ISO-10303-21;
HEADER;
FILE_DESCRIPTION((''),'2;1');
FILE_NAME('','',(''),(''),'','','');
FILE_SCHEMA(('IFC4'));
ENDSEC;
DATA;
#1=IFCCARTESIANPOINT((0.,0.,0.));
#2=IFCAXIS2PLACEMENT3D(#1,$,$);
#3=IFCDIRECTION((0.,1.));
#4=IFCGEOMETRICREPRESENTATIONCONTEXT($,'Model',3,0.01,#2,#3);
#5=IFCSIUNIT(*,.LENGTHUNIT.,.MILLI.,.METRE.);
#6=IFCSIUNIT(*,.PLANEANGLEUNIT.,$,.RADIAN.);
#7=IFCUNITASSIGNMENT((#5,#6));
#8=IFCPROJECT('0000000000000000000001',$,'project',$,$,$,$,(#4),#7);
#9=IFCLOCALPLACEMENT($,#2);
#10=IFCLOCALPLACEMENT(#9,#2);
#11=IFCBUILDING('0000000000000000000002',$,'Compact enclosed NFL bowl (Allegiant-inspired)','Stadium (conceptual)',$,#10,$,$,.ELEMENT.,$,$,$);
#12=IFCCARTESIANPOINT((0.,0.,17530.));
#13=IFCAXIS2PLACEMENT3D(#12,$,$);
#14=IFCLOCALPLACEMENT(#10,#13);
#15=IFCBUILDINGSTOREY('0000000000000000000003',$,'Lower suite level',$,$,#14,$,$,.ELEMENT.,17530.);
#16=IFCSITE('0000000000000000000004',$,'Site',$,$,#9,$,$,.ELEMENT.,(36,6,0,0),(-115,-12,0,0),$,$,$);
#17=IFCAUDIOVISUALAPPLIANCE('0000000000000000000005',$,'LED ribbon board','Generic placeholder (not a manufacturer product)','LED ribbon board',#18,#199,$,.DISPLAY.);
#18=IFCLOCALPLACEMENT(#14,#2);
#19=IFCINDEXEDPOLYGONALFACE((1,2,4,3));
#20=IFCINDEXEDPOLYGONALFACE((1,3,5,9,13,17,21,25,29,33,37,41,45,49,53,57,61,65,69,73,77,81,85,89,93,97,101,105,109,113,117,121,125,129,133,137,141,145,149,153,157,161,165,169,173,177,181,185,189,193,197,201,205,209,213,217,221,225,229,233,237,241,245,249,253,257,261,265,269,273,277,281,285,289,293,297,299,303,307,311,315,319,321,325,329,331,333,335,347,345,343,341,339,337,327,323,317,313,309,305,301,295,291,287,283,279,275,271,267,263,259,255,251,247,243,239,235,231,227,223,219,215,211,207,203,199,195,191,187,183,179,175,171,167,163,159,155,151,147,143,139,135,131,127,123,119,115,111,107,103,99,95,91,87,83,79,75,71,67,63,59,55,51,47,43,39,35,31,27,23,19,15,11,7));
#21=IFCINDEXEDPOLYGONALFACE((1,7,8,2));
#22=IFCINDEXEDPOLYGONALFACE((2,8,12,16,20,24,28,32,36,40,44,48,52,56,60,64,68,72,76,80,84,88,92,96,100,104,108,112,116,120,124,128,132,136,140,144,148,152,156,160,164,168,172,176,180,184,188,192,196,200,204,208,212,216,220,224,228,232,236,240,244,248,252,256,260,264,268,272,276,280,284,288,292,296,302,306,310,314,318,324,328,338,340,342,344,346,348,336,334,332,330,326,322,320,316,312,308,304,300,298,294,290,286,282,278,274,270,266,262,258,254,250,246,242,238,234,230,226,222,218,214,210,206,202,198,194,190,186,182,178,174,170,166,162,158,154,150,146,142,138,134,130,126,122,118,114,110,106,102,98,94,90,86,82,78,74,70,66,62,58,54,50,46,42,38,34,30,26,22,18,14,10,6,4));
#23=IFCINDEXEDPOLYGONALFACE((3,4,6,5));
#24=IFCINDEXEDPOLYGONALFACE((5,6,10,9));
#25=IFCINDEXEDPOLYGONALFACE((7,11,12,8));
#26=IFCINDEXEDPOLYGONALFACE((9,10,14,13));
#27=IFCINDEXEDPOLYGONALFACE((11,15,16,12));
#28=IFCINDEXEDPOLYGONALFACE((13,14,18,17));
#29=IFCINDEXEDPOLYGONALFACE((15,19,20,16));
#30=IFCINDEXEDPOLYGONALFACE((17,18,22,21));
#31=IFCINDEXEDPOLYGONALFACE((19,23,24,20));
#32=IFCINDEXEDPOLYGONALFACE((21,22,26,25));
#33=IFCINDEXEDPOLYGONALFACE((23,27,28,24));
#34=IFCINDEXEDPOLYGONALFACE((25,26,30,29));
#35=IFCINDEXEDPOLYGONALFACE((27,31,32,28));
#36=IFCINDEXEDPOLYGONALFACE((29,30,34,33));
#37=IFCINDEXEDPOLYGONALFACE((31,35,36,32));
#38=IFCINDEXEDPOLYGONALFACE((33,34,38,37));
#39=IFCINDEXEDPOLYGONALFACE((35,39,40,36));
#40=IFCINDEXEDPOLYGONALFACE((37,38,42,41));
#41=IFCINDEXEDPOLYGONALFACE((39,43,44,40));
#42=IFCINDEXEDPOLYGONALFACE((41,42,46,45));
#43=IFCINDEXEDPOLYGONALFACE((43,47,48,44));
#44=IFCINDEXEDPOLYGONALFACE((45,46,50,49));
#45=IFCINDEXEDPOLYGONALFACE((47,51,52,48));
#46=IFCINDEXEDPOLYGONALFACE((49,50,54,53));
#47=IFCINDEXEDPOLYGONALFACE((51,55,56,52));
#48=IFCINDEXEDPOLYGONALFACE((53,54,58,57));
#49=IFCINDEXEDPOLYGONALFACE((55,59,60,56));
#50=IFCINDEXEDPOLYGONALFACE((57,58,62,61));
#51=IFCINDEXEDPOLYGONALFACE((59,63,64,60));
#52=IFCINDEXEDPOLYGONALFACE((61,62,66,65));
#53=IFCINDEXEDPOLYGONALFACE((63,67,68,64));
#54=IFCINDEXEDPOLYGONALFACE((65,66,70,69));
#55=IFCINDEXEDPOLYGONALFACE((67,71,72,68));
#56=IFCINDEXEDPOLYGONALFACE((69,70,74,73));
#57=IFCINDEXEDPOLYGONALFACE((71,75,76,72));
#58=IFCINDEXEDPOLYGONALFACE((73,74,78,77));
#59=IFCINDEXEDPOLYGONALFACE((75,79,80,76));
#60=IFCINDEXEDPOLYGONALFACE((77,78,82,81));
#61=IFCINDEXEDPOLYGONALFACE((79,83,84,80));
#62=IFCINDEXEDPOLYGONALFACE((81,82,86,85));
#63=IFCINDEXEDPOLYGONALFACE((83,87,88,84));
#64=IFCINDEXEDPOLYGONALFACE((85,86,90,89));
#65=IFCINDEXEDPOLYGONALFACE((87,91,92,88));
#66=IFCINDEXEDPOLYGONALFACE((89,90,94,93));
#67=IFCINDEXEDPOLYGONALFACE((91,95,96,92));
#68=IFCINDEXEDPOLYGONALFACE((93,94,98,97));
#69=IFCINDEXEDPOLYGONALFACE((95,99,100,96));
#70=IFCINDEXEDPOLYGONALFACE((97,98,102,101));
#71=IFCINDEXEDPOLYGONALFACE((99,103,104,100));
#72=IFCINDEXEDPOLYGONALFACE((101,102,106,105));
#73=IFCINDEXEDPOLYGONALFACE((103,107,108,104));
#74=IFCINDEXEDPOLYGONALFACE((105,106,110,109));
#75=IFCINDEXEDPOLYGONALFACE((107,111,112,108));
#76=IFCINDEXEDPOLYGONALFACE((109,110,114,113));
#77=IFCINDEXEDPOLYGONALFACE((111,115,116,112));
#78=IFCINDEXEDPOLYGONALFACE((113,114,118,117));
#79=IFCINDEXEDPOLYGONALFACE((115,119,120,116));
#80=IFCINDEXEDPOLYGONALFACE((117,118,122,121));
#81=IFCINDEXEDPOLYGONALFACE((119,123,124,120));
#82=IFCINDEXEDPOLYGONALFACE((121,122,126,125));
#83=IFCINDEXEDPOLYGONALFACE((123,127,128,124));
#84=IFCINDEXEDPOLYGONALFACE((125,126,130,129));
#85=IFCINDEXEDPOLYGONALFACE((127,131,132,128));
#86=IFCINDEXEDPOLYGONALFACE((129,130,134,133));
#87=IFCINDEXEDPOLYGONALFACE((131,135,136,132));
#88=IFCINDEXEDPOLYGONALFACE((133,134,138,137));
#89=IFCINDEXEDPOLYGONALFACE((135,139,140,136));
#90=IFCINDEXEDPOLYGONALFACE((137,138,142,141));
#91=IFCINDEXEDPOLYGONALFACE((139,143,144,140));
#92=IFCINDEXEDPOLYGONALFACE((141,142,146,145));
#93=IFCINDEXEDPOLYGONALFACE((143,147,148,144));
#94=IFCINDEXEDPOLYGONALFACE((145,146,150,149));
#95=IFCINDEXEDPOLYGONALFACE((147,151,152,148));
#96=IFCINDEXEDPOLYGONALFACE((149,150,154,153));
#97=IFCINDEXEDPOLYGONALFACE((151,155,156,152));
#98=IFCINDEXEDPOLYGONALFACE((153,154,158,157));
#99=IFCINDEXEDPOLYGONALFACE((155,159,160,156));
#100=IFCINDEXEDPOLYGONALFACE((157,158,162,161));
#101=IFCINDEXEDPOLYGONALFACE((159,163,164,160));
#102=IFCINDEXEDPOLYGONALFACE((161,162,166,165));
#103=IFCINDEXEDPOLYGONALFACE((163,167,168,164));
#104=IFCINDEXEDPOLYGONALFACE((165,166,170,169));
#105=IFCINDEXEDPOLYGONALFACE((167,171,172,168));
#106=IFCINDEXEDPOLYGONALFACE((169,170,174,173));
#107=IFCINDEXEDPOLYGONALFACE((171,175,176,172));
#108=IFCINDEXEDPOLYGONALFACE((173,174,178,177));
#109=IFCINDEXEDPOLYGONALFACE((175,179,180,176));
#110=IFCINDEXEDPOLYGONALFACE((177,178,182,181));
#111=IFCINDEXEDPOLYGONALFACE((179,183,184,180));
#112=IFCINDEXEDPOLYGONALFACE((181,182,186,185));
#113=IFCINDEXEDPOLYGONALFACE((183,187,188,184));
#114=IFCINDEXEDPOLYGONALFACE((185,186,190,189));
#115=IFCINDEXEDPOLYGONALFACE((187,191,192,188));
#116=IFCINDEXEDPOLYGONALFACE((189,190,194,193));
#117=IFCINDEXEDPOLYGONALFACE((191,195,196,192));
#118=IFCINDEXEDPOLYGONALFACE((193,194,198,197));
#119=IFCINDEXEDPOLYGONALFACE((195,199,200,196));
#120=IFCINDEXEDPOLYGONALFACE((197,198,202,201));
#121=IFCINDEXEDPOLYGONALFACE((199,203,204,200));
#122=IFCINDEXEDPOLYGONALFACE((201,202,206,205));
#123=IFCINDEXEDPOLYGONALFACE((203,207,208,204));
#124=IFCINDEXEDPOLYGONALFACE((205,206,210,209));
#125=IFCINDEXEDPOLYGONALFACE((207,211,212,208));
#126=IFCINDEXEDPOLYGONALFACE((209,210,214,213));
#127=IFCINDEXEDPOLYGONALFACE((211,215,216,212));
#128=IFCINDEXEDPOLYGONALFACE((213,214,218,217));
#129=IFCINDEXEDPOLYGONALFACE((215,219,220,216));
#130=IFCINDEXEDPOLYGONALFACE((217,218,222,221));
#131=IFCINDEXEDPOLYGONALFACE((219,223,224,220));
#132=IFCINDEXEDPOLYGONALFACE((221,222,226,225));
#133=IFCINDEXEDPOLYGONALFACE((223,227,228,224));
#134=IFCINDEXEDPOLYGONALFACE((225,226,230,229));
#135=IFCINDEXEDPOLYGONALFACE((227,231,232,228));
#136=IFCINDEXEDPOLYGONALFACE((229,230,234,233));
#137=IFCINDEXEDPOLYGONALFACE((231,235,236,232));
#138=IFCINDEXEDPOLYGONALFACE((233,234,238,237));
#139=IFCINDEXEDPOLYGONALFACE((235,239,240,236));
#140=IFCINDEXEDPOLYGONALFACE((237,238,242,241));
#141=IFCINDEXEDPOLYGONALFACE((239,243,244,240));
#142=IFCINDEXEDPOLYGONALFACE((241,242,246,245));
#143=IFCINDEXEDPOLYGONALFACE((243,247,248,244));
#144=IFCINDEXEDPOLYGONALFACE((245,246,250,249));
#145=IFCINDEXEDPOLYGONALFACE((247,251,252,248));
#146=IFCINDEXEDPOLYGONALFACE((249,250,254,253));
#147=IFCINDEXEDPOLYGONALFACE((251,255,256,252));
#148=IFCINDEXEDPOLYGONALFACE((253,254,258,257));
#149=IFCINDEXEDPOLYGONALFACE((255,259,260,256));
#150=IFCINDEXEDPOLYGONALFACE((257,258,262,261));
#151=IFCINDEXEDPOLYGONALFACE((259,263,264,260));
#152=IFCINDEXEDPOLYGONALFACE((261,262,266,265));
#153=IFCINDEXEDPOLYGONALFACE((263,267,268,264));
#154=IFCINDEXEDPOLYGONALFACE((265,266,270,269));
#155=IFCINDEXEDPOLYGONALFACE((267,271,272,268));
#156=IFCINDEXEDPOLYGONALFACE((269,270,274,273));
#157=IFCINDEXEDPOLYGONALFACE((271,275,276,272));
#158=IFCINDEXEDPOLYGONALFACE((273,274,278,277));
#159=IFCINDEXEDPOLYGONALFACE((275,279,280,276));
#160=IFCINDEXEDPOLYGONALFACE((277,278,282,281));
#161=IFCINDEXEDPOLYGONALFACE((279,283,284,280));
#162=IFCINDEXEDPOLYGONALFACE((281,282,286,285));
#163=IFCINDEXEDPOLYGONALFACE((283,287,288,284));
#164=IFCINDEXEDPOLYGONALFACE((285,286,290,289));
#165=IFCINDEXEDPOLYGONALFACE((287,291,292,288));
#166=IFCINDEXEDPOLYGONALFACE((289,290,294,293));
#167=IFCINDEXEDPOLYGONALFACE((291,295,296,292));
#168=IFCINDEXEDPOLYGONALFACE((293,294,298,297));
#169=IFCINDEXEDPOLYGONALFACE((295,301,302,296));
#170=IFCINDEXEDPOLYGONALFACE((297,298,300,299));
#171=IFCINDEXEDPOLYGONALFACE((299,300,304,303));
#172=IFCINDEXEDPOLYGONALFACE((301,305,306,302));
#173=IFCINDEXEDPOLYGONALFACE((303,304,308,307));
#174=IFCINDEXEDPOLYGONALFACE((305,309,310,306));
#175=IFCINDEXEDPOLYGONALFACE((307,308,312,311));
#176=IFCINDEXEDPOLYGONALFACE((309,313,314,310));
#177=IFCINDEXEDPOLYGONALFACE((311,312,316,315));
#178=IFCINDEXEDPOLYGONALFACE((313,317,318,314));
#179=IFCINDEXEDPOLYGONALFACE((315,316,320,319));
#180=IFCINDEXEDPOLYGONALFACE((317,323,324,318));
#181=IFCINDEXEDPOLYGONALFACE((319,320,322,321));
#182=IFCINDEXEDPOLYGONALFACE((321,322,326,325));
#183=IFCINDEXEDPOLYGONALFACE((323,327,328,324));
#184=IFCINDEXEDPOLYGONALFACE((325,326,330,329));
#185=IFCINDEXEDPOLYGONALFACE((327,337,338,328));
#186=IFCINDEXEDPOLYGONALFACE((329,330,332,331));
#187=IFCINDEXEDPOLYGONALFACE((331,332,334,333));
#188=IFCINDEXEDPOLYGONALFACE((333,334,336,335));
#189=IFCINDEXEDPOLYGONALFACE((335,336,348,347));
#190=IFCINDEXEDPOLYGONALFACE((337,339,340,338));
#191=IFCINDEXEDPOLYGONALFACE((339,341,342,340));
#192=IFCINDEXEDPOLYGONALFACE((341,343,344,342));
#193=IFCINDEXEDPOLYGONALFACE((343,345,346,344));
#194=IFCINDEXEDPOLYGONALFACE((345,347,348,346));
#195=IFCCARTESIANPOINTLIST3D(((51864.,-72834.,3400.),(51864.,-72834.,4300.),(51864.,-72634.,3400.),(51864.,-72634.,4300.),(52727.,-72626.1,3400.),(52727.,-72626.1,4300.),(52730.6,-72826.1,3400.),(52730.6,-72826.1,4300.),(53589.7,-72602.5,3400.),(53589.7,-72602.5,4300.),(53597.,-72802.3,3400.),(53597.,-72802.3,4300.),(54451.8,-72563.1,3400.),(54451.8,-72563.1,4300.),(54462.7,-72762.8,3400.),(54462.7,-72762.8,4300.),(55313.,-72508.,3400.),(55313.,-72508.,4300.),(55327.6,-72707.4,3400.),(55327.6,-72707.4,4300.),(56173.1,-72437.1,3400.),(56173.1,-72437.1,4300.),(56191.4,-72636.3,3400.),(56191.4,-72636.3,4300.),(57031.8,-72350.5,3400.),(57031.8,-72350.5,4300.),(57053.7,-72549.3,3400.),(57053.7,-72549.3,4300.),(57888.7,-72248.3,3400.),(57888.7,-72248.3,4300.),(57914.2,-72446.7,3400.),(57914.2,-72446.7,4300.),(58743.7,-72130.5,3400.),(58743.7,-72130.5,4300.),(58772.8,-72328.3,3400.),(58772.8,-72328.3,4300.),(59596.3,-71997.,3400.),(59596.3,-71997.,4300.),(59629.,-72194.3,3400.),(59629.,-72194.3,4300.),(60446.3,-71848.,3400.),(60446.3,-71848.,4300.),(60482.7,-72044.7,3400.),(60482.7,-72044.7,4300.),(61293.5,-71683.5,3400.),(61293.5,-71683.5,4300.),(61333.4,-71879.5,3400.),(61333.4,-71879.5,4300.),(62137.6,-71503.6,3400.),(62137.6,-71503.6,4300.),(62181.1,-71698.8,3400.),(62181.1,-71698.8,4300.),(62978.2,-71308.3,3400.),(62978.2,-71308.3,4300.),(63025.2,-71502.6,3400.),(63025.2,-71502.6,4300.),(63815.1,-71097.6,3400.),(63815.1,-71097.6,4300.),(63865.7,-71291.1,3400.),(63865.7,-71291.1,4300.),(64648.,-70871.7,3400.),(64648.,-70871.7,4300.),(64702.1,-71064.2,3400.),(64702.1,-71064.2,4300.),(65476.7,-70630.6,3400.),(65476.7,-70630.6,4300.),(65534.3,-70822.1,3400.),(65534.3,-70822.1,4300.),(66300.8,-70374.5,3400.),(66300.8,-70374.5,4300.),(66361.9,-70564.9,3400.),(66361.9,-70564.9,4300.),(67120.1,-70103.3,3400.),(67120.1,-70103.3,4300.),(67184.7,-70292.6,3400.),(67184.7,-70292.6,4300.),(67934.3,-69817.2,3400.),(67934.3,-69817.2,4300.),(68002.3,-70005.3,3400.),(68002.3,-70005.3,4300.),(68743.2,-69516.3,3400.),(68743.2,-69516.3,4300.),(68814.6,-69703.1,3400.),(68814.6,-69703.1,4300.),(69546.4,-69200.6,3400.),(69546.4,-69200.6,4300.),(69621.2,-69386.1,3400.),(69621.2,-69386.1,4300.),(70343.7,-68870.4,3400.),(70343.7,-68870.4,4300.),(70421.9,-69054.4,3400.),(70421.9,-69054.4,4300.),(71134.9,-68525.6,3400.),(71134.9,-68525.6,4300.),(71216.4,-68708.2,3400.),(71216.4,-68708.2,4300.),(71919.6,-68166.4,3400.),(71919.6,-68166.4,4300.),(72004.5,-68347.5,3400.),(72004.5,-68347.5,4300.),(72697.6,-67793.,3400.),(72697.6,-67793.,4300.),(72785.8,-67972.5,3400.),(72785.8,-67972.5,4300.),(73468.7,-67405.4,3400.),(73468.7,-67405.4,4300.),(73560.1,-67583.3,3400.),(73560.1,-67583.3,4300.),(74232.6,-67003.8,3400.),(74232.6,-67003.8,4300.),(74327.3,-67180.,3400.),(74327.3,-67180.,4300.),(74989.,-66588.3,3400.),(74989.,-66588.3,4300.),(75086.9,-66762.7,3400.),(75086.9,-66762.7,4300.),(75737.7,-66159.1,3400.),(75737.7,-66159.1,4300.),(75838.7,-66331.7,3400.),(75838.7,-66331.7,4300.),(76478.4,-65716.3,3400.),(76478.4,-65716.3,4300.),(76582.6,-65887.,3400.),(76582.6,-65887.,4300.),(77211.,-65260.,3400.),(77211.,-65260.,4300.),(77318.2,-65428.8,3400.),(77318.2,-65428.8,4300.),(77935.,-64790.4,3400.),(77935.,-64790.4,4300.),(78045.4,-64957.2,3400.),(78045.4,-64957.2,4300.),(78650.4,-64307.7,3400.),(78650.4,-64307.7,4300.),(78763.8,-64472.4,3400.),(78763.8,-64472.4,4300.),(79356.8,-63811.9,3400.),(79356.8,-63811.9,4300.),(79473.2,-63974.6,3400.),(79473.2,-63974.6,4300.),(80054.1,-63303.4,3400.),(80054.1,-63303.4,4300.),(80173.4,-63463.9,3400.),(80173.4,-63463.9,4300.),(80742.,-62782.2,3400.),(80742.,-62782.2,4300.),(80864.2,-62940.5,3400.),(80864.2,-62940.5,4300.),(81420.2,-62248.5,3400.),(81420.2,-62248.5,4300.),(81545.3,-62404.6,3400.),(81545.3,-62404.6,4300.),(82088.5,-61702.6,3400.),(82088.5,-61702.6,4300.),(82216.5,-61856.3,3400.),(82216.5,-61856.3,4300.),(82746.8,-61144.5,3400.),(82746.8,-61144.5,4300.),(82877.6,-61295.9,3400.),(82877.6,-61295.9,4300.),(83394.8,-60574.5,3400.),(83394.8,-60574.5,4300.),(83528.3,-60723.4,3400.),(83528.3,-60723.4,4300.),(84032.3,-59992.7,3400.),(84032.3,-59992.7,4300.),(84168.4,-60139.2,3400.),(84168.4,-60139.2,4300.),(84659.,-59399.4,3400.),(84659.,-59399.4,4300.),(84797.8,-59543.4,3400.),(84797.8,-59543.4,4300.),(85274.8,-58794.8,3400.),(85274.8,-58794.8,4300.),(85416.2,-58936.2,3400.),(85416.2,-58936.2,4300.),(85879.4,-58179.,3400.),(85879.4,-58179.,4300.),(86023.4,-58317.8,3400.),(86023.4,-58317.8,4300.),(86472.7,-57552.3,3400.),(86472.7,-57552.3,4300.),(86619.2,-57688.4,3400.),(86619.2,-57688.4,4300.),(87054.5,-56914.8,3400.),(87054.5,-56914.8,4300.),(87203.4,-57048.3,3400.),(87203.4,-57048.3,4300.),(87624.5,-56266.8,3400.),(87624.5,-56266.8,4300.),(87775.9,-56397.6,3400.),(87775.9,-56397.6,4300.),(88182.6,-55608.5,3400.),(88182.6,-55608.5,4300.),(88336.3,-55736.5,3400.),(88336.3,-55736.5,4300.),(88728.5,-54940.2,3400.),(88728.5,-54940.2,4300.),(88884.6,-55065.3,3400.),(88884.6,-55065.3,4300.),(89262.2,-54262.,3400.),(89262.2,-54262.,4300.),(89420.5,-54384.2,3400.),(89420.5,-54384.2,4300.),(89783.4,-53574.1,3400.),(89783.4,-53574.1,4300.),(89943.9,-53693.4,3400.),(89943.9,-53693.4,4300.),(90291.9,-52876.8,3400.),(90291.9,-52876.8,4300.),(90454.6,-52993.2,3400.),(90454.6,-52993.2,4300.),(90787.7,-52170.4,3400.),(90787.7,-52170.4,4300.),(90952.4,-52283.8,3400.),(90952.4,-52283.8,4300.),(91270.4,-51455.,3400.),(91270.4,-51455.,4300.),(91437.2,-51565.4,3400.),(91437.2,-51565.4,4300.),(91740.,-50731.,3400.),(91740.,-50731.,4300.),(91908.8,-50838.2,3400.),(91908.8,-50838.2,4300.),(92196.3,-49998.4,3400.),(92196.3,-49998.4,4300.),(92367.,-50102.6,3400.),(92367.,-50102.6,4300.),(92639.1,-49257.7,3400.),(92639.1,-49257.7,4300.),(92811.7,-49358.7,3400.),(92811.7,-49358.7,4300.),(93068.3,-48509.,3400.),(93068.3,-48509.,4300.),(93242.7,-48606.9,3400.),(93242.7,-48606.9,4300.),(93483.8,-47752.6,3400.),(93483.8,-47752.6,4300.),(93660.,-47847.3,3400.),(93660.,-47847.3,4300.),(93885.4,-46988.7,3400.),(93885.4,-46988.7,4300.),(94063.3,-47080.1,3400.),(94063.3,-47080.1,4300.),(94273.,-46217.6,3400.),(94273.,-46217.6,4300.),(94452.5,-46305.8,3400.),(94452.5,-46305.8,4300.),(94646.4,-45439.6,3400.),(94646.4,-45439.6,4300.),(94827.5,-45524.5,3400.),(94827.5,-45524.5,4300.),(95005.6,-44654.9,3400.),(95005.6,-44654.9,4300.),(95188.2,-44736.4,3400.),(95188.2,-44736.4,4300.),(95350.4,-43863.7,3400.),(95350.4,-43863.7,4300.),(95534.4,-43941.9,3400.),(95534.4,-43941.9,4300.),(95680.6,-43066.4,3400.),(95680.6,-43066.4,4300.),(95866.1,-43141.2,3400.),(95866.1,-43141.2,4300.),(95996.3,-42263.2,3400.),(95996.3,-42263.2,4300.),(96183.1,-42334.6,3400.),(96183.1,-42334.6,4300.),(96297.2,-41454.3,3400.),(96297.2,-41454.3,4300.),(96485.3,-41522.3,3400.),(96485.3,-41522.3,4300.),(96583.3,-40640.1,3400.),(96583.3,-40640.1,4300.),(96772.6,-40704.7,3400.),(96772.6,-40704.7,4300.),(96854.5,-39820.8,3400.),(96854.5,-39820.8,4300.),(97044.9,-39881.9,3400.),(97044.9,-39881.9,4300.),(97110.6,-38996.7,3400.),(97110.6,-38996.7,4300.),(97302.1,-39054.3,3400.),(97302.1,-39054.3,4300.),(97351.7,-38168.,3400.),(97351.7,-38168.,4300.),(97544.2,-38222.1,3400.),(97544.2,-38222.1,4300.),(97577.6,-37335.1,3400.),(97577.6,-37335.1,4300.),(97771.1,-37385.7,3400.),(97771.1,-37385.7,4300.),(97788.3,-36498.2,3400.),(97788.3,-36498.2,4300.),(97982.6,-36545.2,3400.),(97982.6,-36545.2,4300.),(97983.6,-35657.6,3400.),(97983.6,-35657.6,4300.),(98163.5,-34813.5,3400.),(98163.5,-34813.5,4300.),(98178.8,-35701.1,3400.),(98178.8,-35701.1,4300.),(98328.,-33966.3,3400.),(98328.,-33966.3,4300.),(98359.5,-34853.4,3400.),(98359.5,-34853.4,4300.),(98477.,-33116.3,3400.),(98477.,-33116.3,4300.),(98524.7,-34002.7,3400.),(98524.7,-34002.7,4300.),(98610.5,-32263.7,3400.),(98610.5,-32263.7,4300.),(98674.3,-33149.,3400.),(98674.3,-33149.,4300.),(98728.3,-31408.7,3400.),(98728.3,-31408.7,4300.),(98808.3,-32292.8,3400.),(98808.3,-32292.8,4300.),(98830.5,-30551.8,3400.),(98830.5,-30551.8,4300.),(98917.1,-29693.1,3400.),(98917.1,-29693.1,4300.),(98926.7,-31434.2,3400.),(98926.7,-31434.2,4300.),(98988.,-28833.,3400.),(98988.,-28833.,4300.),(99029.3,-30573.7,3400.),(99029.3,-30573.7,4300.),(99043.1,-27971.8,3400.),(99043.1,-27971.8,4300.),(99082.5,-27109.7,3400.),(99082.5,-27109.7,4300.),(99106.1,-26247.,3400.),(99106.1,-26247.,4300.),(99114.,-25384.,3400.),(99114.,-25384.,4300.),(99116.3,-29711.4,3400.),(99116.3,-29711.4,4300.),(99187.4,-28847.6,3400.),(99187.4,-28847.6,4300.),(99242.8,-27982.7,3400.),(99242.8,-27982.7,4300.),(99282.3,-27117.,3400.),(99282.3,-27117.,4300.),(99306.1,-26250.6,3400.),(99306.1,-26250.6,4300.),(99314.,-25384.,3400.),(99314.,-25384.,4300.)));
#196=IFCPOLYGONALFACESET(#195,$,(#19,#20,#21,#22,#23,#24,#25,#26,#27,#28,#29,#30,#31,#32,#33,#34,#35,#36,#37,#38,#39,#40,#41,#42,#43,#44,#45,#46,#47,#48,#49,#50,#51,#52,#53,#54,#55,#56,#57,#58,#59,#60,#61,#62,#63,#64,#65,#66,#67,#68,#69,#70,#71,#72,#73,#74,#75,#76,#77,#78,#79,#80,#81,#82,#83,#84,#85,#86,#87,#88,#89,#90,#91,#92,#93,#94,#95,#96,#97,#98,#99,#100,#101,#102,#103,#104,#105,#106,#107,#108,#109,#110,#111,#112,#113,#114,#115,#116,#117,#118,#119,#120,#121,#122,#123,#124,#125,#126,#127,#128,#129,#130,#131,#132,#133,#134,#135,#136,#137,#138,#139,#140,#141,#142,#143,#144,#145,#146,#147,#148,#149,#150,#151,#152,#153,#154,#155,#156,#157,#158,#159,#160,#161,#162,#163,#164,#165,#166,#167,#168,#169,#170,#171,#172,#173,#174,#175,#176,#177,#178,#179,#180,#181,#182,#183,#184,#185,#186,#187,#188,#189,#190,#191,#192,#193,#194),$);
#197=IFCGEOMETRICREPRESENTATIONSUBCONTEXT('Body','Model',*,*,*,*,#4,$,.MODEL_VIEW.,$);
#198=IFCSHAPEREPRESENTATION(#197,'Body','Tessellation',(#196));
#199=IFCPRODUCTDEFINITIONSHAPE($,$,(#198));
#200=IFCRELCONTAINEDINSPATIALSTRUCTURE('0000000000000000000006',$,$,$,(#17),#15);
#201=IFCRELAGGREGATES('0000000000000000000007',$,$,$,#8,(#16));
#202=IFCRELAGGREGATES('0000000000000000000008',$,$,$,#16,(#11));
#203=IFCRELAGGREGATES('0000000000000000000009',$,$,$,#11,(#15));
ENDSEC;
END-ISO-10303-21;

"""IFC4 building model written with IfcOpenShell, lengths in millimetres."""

from ifc_helpers import new_model, si_unit, direction, frame, origin, place, context, subcontext, project, spatial, line, arc, indexed_curve, outline, extrude, element, save


model = new_model("IFC4")

# Units and contexts
model_context = context("Model", 3, precision=0.01, world=origin(), true_north=direction((0.0, 1.0)))
body_context = subcontext(model_context, "Body", "Model", "MODEL_VIEW")
ifc_project = project(units=[si_unit("LENGTHUNIT", "METRE", prefix="MILLI"), si_unit("PLANEANGLEUNIT", "RADIAN")], contexts=[model_context])

# Site, building, storey
site_placement = place(None, origin())
site = spatial("IfcSite", under=ifc_project, at=site_placement, Name="Site", CompositionType="ELEMENT", RefLatitude=(36, 6, 0, 0), RefLongitude=(-115, -12, 0, 0))
building_placement = place(site_placement, origin())
building = spatial("IfcBuilding", under=site, at=building_placement, Name="Compact enclosed NFL bowl (Allegiant-inspired)", Description="Stadium (conceptual)", CompositionType="ELEMENT")
storey_placement = place(building_placement, frame((0.0, 0.0, 17530.0)))
storey = spatial("IfcBuildingStorey", under=building, at=storey_placement, Name="Lower suite level", CompositionType="ELEMENT", Elevation=17530.0)

# Shared definitions
placement = place(storey_placement, frame((0.0, 0.0, -17530.0)))

# Audio visual appliance
element("IfcAudioVisualAppliance", 1, at=placement, inside=storey, Name="LED ribbon board", Description="Generic placeholder (not a manufacturer product)", ObjectType="LED ribbon board", PredefinedType="DISPLAY", context=body_context, shape_type="SweptSolid", body=[
    extrude(outline(indexed_curve([(51864.0, -72634.0), (85274.8, -58794.8), (99114.0, -25384.0), (99314.0, -25384.0), (85416.2, -58936.2), (51864.0, -72834.0)], segments=[arc(1, 2, 3), line(3, 4), arc(4, 5, 6), line(6, 1)], self_intersect=False)), frame((0.0, 0.0, 20930.0)), (0.0, 0.0, 1.0), 900.0),
])

save(model, "model.ifc")
